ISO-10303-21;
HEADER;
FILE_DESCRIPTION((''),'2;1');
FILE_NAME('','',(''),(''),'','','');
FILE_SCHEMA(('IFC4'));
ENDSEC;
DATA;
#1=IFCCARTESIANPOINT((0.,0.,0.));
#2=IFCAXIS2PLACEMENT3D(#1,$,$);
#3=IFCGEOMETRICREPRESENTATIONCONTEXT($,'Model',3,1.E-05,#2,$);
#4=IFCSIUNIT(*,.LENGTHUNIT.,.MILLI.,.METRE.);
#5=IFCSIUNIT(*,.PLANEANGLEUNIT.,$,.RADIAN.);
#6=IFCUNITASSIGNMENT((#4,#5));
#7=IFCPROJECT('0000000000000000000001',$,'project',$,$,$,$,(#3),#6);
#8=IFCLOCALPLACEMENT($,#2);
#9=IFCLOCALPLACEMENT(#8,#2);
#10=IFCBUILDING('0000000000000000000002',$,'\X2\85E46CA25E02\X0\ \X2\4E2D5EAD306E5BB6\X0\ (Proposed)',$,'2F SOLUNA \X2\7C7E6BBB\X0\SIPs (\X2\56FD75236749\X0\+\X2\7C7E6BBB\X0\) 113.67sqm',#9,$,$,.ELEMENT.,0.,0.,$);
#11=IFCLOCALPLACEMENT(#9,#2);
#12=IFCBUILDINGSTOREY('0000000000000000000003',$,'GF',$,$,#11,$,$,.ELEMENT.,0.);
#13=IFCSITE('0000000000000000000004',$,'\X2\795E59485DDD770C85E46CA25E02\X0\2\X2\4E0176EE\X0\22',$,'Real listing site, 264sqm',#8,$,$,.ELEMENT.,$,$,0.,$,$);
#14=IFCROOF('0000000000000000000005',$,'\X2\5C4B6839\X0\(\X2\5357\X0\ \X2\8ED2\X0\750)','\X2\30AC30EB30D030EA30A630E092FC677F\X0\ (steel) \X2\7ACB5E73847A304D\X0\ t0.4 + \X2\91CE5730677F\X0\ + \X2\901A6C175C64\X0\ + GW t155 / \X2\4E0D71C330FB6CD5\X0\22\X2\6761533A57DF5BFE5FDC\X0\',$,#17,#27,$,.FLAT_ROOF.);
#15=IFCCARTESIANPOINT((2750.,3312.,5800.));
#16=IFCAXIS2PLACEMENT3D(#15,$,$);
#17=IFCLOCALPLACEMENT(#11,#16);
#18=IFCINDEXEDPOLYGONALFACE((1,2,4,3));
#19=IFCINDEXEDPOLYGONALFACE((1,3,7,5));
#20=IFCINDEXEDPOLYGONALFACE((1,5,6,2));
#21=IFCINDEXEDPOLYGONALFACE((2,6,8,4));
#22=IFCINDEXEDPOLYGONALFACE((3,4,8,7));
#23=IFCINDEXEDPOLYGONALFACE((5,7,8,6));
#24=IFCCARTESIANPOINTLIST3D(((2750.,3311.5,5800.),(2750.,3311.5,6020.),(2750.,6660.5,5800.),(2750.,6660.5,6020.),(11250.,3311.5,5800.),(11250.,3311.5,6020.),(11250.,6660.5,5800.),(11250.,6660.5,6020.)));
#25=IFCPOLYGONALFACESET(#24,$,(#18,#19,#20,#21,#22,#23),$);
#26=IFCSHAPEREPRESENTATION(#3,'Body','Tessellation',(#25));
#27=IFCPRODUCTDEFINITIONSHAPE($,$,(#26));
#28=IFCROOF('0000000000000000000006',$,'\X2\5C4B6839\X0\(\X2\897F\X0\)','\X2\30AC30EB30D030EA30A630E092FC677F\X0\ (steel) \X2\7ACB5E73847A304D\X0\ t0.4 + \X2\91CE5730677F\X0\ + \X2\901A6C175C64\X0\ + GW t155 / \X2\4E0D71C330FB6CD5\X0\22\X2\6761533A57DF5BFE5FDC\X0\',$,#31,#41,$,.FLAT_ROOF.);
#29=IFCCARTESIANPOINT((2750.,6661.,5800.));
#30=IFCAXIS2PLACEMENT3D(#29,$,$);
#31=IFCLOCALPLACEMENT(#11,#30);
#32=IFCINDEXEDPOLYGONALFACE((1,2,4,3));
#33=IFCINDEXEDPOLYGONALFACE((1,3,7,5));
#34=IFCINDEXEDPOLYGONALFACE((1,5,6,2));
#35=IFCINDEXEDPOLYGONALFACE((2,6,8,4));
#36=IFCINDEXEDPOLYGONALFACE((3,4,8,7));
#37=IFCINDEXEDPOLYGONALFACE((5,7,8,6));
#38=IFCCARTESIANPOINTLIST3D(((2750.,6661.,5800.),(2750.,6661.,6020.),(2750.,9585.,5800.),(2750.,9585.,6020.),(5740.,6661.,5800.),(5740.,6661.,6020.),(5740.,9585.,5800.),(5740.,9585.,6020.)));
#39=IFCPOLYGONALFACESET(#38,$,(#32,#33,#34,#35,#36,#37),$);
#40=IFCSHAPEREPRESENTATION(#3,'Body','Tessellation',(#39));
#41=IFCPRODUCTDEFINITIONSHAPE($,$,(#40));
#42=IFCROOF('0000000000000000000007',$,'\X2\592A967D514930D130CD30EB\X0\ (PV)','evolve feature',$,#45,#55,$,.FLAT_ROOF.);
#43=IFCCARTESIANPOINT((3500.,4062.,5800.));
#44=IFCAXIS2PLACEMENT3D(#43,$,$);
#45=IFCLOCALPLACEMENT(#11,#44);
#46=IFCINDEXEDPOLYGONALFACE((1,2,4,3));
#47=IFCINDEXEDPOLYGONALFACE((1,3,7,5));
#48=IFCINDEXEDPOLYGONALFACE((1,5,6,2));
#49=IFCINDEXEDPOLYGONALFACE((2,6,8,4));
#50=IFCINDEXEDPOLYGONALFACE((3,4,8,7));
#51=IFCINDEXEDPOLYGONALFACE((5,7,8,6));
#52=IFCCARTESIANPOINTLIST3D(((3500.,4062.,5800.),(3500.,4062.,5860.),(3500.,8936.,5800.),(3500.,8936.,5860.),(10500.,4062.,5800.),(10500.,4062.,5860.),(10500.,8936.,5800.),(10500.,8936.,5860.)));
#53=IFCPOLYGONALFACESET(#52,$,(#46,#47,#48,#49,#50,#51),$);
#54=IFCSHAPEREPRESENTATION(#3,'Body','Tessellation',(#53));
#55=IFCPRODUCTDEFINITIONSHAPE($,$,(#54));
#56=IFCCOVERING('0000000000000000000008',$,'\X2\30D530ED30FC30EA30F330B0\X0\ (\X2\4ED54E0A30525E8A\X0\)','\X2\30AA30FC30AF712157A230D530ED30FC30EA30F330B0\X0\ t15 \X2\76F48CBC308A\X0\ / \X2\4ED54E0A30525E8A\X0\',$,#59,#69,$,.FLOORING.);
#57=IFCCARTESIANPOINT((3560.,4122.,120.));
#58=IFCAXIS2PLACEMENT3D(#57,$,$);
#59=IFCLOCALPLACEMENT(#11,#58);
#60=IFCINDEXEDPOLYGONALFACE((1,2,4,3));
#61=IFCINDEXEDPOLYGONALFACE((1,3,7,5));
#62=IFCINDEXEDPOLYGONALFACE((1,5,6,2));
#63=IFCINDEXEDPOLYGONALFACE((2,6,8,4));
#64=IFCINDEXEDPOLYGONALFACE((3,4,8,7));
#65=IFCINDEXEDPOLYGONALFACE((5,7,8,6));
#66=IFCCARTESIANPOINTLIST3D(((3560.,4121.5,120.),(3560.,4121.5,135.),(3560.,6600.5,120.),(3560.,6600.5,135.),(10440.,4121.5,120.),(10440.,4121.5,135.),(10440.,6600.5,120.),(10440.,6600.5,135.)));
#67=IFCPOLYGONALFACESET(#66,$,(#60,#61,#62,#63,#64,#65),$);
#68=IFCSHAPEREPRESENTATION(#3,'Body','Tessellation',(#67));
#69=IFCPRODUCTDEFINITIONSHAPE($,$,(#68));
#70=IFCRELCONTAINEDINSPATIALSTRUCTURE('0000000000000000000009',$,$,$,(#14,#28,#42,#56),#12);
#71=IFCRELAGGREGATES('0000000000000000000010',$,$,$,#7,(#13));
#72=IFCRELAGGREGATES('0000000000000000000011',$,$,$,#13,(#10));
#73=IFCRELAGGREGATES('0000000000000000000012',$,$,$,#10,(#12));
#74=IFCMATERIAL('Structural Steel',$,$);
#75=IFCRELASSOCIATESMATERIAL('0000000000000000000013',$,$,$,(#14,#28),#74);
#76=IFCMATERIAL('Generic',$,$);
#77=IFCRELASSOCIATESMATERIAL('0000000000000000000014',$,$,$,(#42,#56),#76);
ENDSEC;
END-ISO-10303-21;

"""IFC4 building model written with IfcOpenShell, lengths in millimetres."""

from ifc_helpers import new_model, si_unit, frame, frame_2d, origin, place, context, project, spatial, rectangle, extrude, material, element, save


model = new_model("IFC4")

# Units and contexts
model_context = context("Model", 3, precision=1e-05, world=origin())
ifc_project = project(units=[si_unit("LENGTHUNIT", "METRE", prefix="MILLI"), si_unit("PLANEANGLEUNIT", "RADIAN")], contexts=[model_context])

# Site, building, storey
site_placement = place(None, origin())
site = spatial("IfcSite", under=ifc_project, at=site_placement, Name="神奈川県藤沢市2丁目22", ObjectType="Real listing site, 264sqm", CompositionType="ELEMENT", RefElevation=0.0)
building_placement = place(site_placement, origin())
building = spatial("IfcBuilding", under=site, at=building_placement, Name="藤沢市 中庭の家 (Proposed)", ObjectType="2F SOLUNA 籾殻SIPs (国産杉+籾殻) 113.67sqm", CompositionType="ELEMENT", ElevationOfRefHeight=0.0, ElevationOfTerrain=0.0)
storey_placement = place(building_placement, origin())
storey = spatial("IfcBuildingStorey", under=building, at=storey_placement, Name="GF", CompositionType="ELEMENT", Elevation=0.0)

# Shared definitions
ifc_material_1 = material(Name="Generic")

# Roofs
ifc_material_2 = material(Name="Structural Steel")
roof_1_placement = place(storey_placement, frame((2750.0, 3312.0, 5800.0)))
element("IfcRoof", 1, at=roof_1_placement, inside=storey, material=ifc_material_2, Name="屋根(南 軒750)", Description="ガルバリウム鋼板 (steel) 立平葺き t0.4 + 野地板 + 通気層 + GW t155 / 不燃・法22条区域対応", PredefinedType="FLAT_ROOF", context=model_context, shape_type="SweptSolid", body=[
    extrude(rectangle(XDim=8500.0, YDim=3349.0, at=frame_2d((4250.0, 1674.0))), frame((2750.0, 3312.0, 5800.0)), (0.0, 0.0, 1.0), 220.0),
])
roof_2_placement = place(storey_placement, frame((2750.0, 6661.0, 5800.0)))
element("IfcRoof", 2, at=roof_2_placement, inside=storey, material=ifc_material_2, Name="屋根(西)", Description="ガルバリウム鋼板 (steel) 立平葺き t0.4 + 野地板 + 通気層 + GW t155 / 不燃・法22条区域対応", PredefinedType="FLAT_ROOF", context=model_context, shape_type="SweptSolid", body=[
    extrude(rectangle(XDim=2990.0, YDim=2924.0, at=frame_2d((1495.0, 1462.0))), frame((2750.0, 6661.0, 5800.0)), (0.0, 0.0, 1.0), 220.0),
])
roof_3_placement = place(storey_placement, frame((3500.0, 4062.0, 5800.0)))
element("IfcRoof", 3, at=roof_3_placement, inside=storey, material=ifc_material_1, Name="太陽光パネル (PV)", Description="evolve feature", PredefinedType="FLAT_ROOF", context=model_context, shape_type="SweptSolid", body=[
    extrude(rectangle(XDim=7000.0, YDim=4874.0, at=frame_2d((3500.0, 2437.0))), frame((3500.0, 4062.0, 5800.0)), (0.0, 0.0, 1.0), 60.0),
])

# Covering
covering_placement = place(storey_placement, frame((3560.0, 4122.0, 120.0)))
element("IfcCovering", 4, at=covering_placement, inside=storey, material=ifc_material_1, Name="フローリング (仕上げ床)", Description="オーク無垢フローリング t15 直貼り / 仕上げ床", PredefinedType="FLOORING", context=model_context, shape_type="SweptSolid", body=[
    extrude(rectangle(XDim=6880.0, YDim=2479.0, at=frame_2d((3440.0, 1239.0))), frame((3560.0, 4122.0, 120.0)), (0.0, 0.0, 1.0), 15.0),
])

save(model, "model.ifc")
